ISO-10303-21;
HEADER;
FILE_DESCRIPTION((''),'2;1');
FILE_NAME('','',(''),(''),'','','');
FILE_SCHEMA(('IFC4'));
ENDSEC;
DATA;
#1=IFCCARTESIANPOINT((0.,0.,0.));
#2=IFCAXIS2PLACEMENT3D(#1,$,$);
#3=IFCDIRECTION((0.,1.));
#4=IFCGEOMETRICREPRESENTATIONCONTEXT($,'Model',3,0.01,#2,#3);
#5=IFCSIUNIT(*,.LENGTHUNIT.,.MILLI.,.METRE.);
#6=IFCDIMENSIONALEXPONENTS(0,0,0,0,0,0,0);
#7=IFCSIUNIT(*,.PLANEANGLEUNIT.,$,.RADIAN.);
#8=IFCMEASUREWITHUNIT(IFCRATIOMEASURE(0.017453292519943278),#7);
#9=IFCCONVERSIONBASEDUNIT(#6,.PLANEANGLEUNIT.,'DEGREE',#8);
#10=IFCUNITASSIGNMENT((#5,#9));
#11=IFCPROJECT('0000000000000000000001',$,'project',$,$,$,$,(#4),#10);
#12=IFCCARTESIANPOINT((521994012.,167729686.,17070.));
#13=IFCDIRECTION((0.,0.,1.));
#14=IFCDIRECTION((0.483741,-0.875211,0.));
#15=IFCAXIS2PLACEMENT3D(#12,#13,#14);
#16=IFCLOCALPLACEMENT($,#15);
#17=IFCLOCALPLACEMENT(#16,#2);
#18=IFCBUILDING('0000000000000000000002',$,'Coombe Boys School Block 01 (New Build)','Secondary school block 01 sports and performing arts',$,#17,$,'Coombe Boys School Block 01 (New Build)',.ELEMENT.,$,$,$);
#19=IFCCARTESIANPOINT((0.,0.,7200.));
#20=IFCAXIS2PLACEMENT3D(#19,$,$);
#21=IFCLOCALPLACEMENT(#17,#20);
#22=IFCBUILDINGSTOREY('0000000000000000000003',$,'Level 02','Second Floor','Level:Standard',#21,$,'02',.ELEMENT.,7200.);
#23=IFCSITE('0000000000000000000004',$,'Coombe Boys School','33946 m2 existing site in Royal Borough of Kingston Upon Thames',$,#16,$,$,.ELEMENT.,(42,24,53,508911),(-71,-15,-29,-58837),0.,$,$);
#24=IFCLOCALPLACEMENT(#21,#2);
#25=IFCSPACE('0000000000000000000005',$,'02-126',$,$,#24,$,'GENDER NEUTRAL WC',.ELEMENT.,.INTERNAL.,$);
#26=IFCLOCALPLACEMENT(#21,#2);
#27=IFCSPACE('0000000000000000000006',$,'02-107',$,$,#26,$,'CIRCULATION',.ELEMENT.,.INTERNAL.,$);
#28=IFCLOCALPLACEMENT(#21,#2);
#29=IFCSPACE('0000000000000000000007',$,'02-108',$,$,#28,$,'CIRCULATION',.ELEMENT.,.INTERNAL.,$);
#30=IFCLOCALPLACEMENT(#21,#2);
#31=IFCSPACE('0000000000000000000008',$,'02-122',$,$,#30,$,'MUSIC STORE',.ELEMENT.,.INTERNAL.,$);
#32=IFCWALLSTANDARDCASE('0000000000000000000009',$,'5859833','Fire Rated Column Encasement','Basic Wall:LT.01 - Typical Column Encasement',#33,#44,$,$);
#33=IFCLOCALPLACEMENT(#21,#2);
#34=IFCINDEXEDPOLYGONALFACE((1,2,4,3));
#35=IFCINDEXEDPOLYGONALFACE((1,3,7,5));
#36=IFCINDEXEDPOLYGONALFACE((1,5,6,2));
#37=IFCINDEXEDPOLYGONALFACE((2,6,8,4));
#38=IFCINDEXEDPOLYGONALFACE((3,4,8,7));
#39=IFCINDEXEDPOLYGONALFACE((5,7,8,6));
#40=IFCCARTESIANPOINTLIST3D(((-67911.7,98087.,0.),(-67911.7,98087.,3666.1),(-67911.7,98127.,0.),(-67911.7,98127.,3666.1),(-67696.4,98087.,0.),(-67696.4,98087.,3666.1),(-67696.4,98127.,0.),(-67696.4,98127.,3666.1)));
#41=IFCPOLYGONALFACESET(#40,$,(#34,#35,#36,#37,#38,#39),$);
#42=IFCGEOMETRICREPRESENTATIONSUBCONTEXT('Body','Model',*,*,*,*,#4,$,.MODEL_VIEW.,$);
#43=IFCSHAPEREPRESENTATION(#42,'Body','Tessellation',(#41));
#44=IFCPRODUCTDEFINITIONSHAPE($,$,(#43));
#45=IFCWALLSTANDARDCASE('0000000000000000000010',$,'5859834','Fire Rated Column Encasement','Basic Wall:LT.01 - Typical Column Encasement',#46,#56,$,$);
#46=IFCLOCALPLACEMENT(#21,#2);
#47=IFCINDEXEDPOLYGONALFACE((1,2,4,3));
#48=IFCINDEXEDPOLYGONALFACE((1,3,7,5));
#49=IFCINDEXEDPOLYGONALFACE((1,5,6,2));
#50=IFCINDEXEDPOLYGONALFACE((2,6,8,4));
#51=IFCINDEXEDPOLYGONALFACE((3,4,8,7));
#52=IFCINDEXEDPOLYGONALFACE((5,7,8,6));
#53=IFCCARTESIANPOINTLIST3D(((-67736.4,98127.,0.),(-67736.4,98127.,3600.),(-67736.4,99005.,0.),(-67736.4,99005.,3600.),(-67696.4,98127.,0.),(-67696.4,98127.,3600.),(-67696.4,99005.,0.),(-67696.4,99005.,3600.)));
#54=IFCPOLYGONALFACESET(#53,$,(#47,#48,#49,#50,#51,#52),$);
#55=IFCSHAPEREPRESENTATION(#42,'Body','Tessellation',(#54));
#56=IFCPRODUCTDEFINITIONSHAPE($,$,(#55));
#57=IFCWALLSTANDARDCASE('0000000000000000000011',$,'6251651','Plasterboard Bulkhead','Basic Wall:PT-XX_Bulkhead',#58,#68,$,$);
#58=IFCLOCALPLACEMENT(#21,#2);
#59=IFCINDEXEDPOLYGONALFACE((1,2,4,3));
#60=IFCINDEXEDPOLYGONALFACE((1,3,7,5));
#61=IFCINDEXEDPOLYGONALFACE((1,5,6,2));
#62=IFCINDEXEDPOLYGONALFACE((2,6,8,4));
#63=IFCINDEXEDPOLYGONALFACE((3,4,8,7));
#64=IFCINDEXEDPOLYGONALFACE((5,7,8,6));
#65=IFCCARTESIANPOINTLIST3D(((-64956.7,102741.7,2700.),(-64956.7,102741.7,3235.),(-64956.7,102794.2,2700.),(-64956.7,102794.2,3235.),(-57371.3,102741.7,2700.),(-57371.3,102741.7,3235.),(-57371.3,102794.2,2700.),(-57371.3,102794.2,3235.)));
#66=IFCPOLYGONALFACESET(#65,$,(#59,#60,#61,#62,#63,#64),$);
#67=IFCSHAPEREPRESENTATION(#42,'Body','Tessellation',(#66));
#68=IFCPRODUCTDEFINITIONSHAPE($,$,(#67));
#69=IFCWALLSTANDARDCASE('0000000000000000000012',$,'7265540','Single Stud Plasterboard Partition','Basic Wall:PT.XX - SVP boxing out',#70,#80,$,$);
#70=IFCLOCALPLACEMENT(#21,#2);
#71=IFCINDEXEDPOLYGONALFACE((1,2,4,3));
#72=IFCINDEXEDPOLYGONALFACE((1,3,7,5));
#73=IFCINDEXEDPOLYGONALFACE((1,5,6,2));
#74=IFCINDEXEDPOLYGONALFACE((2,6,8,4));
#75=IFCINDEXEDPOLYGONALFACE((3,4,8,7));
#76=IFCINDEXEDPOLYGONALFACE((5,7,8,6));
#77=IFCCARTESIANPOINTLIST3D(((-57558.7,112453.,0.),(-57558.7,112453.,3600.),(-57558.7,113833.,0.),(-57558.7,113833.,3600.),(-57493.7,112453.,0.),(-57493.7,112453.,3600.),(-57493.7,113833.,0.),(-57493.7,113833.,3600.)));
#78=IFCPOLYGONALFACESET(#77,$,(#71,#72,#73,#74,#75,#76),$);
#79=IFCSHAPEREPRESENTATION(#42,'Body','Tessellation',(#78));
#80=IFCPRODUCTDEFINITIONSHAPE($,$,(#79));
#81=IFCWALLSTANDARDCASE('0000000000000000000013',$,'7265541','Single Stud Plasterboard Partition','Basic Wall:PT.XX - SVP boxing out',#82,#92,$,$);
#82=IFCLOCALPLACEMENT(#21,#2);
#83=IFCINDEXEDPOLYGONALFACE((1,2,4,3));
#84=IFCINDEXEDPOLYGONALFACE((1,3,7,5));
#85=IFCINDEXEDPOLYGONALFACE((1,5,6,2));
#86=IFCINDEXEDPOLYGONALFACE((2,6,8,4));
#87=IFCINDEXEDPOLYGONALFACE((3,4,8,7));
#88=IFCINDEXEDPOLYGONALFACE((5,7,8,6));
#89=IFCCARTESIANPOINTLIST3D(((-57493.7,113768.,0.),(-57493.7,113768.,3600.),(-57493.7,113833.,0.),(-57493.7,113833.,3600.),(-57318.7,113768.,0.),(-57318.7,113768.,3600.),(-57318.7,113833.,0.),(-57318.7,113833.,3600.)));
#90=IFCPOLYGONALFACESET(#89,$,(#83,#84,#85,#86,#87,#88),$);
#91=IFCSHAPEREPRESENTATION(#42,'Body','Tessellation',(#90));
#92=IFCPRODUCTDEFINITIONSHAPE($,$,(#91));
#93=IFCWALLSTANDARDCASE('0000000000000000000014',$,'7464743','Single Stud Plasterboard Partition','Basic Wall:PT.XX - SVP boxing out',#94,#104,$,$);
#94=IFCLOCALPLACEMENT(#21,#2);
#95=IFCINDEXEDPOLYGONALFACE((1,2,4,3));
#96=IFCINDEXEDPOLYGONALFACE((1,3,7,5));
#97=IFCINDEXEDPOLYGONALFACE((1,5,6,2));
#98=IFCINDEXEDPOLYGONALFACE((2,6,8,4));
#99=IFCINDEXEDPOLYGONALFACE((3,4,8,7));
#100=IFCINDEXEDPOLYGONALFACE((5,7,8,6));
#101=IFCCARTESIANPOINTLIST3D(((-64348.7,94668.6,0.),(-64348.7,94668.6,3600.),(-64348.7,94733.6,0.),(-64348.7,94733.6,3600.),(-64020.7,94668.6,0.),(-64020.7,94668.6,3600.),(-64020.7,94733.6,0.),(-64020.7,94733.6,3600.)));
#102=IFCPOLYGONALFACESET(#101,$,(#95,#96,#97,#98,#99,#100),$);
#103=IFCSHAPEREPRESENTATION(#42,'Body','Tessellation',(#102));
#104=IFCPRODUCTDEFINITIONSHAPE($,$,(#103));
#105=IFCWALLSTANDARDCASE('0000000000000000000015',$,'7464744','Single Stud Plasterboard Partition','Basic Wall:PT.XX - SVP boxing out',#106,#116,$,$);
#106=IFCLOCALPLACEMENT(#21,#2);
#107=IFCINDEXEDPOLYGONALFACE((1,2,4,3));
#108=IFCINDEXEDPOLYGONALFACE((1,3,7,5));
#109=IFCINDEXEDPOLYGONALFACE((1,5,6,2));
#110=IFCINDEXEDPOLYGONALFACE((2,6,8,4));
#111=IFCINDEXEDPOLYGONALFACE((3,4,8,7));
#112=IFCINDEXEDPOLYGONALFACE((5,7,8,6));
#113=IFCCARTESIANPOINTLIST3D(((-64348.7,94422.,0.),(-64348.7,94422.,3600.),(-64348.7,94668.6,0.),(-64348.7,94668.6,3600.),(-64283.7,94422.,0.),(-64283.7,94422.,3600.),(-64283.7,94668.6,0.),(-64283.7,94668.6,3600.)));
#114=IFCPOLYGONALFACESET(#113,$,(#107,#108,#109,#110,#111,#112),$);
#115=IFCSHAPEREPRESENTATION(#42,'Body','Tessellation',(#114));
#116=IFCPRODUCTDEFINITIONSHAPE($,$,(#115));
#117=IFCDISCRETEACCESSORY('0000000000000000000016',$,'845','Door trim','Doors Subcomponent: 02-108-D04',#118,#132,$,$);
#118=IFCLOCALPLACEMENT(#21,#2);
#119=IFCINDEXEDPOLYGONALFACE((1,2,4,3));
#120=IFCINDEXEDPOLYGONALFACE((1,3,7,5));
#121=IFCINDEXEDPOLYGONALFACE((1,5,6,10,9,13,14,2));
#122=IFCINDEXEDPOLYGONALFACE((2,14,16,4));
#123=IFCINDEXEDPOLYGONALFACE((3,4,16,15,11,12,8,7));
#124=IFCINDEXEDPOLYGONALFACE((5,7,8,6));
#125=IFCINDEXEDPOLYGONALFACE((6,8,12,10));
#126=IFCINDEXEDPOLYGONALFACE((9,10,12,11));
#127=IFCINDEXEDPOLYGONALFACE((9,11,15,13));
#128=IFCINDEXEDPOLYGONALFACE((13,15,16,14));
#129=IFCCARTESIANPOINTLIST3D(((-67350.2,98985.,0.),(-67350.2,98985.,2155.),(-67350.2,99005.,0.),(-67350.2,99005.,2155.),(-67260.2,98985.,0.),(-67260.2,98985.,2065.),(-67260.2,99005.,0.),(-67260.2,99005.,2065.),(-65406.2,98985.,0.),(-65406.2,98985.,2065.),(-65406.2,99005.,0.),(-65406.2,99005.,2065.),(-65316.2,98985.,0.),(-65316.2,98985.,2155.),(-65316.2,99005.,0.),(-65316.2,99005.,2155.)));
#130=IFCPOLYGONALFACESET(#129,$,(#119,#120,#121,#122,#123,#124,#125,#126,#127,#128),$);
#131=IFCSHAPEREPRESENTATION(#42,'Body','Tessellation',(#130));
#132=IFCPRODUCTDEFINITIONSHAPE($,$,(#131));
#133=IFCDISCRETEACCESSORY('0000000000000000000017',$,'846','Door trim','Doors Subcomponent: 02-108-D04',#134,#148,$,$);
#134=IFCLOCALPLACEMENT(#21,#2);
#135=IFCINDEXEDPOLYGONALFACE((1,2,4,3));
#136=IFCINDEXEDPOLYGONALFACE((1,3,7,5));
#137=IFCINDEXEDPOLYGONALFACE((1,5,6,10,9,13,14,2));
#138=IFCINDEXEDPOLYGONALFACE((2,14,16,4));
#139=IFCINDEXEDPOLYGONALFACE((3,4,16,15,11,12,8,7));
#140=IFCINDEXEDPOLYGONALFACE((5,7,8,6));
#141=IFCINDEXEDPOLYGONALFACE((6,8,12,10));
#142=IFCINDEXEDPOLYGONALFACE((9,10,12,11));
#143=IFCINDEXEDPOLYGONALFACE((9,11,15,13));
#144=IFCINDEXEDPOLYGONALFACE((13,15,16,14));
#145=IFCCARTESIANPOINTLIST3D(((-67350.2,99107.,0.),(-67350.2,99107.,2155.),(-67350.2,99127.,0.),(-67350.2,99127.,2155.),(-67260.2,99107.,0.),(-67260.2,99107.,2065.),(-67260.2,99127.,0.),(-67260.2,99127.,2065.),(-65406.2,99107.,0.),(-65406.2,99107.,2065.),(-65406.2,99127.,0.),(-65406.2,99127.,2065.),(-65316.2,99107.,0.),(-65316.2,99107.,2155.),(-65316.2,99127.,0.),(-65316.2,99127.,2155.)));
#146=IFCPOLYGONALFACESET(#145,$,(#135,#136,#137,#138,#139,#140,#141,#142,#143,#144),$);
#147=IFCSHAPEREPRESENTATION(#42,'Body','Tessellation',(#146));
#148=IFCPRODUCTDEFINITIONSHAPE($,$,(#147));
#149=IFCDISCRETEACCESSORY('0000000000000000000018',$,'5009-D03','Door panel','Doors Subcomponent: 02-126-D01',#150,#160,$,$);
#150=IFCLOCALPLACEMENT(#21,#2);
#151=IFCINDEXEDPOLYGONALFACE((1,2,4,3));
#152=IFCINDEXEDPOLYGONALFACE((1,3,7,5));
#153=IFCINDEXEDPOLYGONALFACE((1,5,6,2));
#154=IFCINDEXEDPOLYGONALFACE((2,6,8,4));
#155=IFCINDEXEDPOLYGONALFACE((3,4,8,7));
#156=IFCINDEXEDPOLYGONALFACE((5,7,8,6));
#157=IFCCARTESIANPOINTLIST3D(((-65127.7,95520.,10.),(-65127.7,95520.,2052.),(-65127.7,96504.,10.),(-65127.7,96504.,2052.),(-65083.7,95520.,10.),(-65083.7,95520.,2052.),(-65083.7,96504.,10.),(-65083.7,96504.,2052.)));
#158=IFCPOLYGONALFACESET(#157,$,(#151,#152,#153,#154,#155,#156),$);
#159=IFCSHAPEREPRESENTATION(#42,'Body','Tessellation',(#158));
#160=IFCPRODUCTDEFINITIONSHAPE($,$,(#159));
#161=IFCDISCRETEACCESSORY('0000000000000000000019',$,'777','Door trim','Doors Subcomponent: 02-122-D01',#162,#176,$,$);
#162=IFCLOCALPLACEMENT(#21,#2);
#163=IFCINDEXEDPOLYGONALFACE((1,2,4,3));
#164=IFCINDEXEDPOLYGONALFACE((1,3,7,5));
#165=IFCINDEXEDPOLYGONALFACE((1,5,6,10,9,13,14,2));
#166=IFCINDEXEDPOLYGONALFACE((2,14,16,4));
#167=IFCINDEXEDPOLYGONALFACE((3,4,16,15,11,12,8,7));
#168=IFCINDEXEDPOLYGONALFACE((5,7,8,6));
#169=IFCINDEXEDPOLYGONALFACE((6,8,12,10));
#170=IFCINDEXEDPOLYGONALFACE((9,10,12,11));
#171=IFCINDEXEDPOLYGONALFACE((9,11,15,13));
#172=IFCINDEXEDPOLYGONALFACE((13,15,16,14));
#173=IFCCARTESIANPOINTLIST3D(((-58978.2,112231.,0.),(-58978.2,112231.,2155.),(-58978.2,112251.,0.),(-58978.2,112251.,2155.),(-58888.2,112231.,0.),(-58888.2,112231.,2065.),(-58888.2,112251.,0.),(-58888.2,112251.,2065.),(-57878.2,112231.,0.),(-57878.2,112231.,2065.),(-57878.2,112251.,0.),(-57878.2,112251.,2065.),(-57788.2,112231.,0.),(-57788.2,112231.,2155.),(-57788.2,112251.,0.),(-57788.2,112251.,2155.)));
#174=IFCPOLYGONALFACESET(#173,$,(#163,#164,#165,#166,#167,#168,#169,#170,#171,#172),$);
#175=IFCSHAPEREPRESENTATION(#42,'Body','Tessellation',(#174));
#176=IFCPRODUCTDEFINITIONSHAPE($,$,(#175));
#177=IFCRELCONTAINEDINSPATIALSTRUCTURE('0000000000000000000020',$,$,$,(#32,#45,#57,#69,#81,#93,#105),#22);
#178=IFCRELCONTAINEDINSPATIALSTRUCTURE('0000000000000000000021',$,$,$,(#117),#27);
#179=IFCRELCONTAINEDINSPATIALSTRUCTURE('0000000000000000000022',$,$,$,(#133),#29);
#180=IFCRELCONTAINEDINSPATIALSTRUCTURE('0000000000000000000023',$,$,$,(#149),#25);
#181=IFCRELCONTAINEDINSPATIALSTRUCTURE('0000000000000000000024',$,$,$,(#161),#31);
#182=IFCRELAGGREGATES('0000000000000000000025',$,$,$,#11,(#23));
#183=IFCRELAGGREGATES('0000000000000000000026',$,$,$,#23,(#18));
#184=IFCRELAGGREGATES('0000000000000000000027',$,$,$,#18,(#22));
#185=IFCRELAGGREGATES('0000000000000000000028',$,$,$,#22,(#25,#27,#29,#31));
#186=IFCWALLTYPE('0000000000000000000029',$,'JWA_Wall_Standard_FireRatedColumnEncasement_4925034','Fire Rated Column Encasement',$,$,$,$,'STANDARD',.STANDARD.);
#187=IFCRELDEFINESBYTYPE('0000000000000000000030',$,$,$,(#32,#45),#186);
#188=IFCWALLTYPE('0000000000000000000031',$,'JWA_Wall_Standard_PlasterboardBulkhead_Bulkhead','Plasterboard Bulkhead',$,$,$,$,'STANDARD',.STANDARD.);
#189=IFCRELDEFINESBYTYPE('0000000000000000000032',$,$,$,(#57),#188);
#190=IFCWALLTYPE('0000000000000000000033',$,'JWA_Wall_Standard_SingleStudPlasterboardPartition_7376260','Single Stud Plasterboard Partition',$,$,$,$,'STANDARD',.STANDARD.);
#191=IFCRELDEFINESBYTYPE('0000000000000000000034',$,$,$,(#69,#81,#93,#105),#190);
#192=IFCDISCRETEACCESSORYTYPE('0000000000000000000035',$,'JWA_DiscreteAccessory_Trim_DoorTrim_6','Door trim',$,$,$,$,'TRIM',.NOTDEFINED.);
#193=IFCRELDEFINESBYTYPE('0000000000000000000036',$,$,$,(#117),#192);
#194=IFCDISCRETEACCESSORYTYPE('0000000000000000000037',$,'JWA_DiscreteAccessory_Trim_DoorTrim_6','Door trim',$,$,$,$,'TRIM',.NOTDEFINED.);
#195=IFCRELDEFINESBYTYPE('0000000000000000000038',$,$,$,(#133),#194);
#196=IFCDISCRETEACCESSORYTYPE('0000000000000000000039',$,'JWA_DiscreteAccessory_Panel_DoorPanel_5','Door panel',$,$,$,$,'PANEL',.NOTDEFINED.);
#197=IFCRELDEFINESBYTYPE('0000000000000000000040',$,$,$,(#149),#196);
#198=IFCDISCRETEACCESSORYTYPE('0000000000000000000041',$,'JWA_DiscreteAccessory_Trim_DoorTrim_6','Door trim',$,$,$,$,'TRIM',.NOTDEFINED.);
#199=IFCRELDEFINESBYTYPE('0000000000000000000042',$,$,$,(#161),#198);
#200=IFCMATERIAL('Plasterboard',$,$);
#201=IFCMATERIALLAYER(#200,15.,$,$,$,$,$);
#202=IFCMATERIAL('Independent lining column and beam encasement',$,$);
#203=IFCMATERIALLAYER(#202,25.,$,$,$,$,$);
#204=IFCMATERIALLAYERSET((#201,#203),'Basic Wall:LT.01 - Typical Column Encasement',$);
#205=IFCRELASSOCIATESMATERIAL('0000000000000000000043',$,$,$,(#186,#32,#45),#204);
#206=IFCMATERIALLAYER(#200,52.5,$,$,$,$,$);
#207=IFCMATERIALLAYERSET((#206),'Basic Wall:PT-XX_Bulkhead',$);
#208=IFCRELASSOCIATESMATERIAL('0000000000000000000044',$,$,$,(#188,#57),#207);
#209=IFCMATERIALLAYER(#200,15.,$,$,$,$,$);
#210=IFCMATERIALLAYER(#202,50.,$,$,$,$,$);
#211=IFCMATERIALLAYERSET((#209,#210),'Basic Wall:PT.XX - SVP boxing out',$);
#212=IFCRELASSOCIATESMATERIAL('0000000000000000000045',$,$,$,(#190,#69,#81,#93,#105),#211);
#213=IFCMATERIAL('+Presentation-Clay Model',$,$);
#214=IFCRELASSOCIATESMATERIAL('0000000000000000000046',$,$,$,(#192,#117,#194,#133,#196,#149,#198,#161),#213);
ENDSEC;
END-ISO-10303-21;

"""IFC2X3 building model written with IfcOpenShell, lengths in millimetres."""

from ifc_helpers import new_model, entity, si_unit, converted_unit, direction, frame, frame_2d, origin, origin_2d_with_axis, place, context, subcontext, project, spatial, polyline, rectangle, outline, extrude, source, transform, mapped, material, layer, layer_set, layer_usage, type_object, type_shapes, element, save


model = new_model("IFC2X3")

# Units and contexts
model_context = context("Model", 3, precision=0.01, world=origin(), true_north=direction((0.0, 1.0)))
body_context = subcontext(model_context, "Body", "Model", "MODEL_VIEW")
ifc_project = project(units=[si_unit("LENGTHUNIT", "METRE", prefix="MILLI"), converted_unit("PLANEANGLEUNIT", "DEGREE", entity("IfcRatioMeasure", 0.017453292519943278), si_unit("PLANEANGLEUNIT", "RADIAN"), dimensions=[0, 0, 0, 0, 0, 0, 0])], contexts=[model_context])

# Site, building, storey
site_placement = place(None, frame((521994012.0, 167729686.0, 17070.0), z_axis=(0.0, 0.0, 1.0), x_axis=(0.483741, -0.875211, 0.0)))
site = spatial("IfcSite", under=ifc_project, at=site_placement, Name="Coombe Boys School", Description="33946 m2 existing site in Royal Borough of Kingston Upon Thames", CompositionType="ELEMENT", RefLatitude=(42, 24, 53, 508911), RefLongitude=(-71, -15, -29, -58837), RefElevation=0.0)
building_placement = place(site_placement, origin())
building = spatial("IfcBuilding", under=site, at=building_placement, Name="Coombe Boys School Block 01 (New Build)", Description="Secondary school block 01 sports and performing arts", LongName="Coombe Boys School Block 01 (New Build)", CompositionType="ELEMENT")
storey_placement = place(building_placement, frame((0.0, 0.0, 7200.0)))
storey = spatial("IfcBuildingStorey", under=building, at=storey_placement, Name="Level 02", Description="Second Floor", ObjectType="Level:Standard", LongName="02", CompositionType="ELEMENT", Elevation=7200.0)

# Shared definitions
ifc_material_1 = material(Name="Plasterboard")

# Walls
ifc_layer_1 = layer(ifc_material_1, 15.0)
ifc_material_2 = material(Name="Independent lining column and beam encasement")
ifc_layer_2 = layer(ifc_material_2, 25.0)
ifc_layer_set_1 = layer_set([ifc_layer_1, ifc_layer_2], Name="Basic Wall:LT.01 - Typical Column Encasement")
ifc_layer_usage_1 = layer_usage(ifc_layer_set_1, "AXIS2", "POSITIVE", -20.0)
wall_type_1 = type_object("IfcWallType", Name="JWA_Wall_Standard_FireRatedColumnEncasement_4925034", Description="Fire Rated Column Encasement", ElementType="STANDARD", PredefinedType="STANDARD", material=ifc_layer_set_1)
wall_1_placement = place(storey_placement, frame((-67911.7, 98107.0, 0.0)))
element("IfcWallStandardCase", 1, at=wall_1_placement, inside=storey, type_object=wall_type_1, material=ifc_layer_usage_1, Name="5859833", Description="Fire Rated Column Encasement", ObjectType="Basic Wall:LT.01 - Typical Column Encasement", context=body_context, shape_type="SweptSolid", body=[
    extrude(rectangle(XDim=215.3, YDim=40.0, at=frame_2d((107.7, 0.0), x_axis=(-1.0, 0.0))), origin(), (0.0, 0.0, 1.0), 3666.1),
])
wall_2_placement = place(storey_placement, frame((-67716.4, 98127.0, 0.0), z_axis=(0.0, 0.0, 1.0), x_axis=(0.0, 1.0, 0.0)))
element("IfcWallStandardCase", 2, at=wall_2_placement, inside=storey, type_object=wall_type_1, material=ifc_layer_usage_1, Name="5859834", Description="Fire Rated Column Encasement", ObjectType="Basic Wall:LT.01 - Typical Column Encasement", context=body_context, shape_type="SweptSolid", body=[
    extrude(rectangle(XDim=878.0, YDim=40.0, at=frame_2d((439.0, 0.0), x_axis=(-1.0, 0.0))), origin(), (0.0, 0.0, 1.0), 3600.0),
])
ifc_layer_3 = layer(ifc_material_1, 52.5)
ifc_layer_set_2 = layer_set([ifc_layer_3], Name="Basic Wall:PT-XX_Bulkhead")
ifc_layer_usage_2 = layer_usage(ifc_layer_set_2, "AXIS2", "NEGATIVE", 26.2)
wall_type_2 = type_object("IfcWallType", Name="JWA_Wall_Standard_PlasterboardBulkhead_Bulkhead", Description="Plasterboard Bulkhead", ElementType="STANDARD", PredefinedType="STANDARD", material=ifc_layer_set_2)
wall_3_placement = place(storey_placement, frame((-64956.7, 102768.0, 2700.0)))
element("IfcWallStandardCase", 3, at=wall_3_placement, inside=storey, type_object=wall_type_2, material=ifc_layer_usage_2, Name="6251651", Description="Plasterboard Bulkhead", ObjectType="Basic Wall:PT-XX_Bulkhead", context=body_context, shape_type="SweptSolid", body=[
    extrude(rectangle(XDim=7585.4, YDim=52.5, at=frame_2d((3792.7, 0.0), x_axis=(-1.0, 0.0))), origin(), (0.0, 0.0, 1.0), 535.0),
])
ifc_layer_4 = layer(ifc_material_1, 15.0)
ifc_layer_5 = layer(ifc_material_2, 50.0)
ifc_layer_set_3 = layer_set([ifc_layer_4, ifc_layer_5], Name="Basic Wall:PT.XX - SVP boxing out")
ifc_layer_usage_3 = layer_usage(ifc_layer_set_3, "AXIS2", "NEGATIVE", 32.5)
wall_type_3 = type_object("IfcWallType", Name="JWA_Wall_Standard_SingleStudPlasterboardPartition_7376260", Description="Single Stud Plasterboard Partition", ElementType="STANDARD", PredefinedType="STANDARD", material=ifc_layer_set_3)
wall_4_placement = place(storey_placement, frame((-57526.2, 112453.0, 0.0), z_axis=(0.0, 0.0, 1.0), x_axis=(0.0, 1.0, 0.0)))
element("IfcWallStandardCase", 4, at=wall_4_placement, inside=storey, type_object=wall_type_3, material=ifc_layer_usage_3, Name="7265540", Description="Single Stud Plasterboard Partition", ObjectType="Basic Wall:PT.XX - SVP boxing out", context=body_context, shape_type="SweptSolid", body=[
    extrude(rectangle(XDim=1380.0, YDim=65.0, at=frame_2d((690.0, 0.0), x_axis=(-1.0, 0.0))), origin(), (0.0, 0.0, 1.0), 3600.0),
])
wall_5_placement = place(storey_placement, frame((-57493.7, 113800.5, 0.0)))
element("IfcWallStandardCase", 5, at=wall_5_placement, inside=storey, type_object=wall_type_3, material=ifc_layer_usage_3, Name="7265541", Description="Single Stud Plasterboard Partition", ObjectType="Basic Wall:PT.XX - SVP boxing out", context=body_context, shape_type="SweptSolid", body=[
    extrude(rectangle(XDim=175.0, YDim=65.0, at=frame_2d((87.5, 0.0), x_axis=(-1.0, 0.0))), origin(), (0.0, 0.0, 1.0), 3600.0),
])
ifc_layer_usage_4 = layer_usage(ifc_layer_set_3, "AXIS2", "POSITIVE", -32.5)
wall_6_placement = place(storey_placement, frame((-64020.7, 94701.1, 0.0), z_axis=(0.0, 0.0, 1.0), x_axis=(-1.0, 0.0, 0.0)))
element("IfcWallStandardCase", 6, at=wall_6_placement, inside=storey, type_object=wall_type_3, material=ifc_layer_usage_4, Name="7464743", Description="Single Stud Plasterboard Partition", ObjectType="Basic Wall:PT.XX - SVP boxing out", context=body_context, shape_type="SweptSolid", body=[
    extrude(rectangle(XDim=328.0, YDim=65.0, at=frame_2d((164.0, 0.0), x_axis=(-1.0, 0.0))), origin(), (0.0, 0.0, 1.0), 3600.0),
])
wall_7_placement = place(storey_placement, frame((-64316.2, 94668.6, 0.0), z_axis=(0.0, 0.0, 1.0), x_axis=(0.0, -1.0, 0.0)))
element("IfcWallStandardCase", 7, at=wall_7_placement, inside=storey, type_object=wall_type_3, material=ifc_layer_usage_4, Name="7464744", Description="Single Stud Plasterboard Partition", ObjectType="Basic Wall:PT.XX - SVP boxing out", context=body_context, shape_type="SweptSolid", body=[
    extrude(rectangle(XDim=246.6, YDim=65.0, at=frame_2d((123.3, 0.0), x_axis=(-1.0, 0.0))), origin(), (0.0, 0.0, 1.0), 3600.0),
])

# Shared definitions
space_1_placement = place(storey_placement, origin())
space_1 = spatial("IfcSpace", under=storey, at=space_1_placement, Name="02-126", LongName="GENDER NEUTRAL WC", CompositionType="ELEMENT", InteriorOrExteriorSpace="INTERNAL")

# Shared definitions
ifc_material_3 = material(Name="+Presentation-Clay Model")

# Shared definitions
space_2_placement = place(storey_placement, origin())
space_2 = spatial("IfcSpace", under=storey, at=space_2_placement, Name="02-107", LongName="CIRCULATION", CompositionType="ELEMENT", InteriorOrExteriorSpace="INTERNAL")

# Discrete accessory
discrete_accessory_type_1 = type_object("IfcDiscreteAccessoryType", Name="JWA_DiscreteAccessory_Trim_DoorTrim_6", Description="Door trim", ElementType="TRIM", material=ifc_material_3)
shared_shape_1 = source(origin(), body_context, "Body", "SweptSolid", [
    extrude(outline(polyline([(-1055.0, -1017.0), (1100.0, -1017.0), (1100.0, 1017.0), (-1055.0, 1017.0), (-1055.0, 927.0), (1010.0, 927.0), (1010.0, -927.0), (-1055.0, -927.0), (-1055.0, -1017.0)])), frame((0.0, -20.0, 1055.0), z_axis=(0.0, 1.0, 0.0), x_axis=(0.0, 0.0, 1.0)), (0.0, 0.0, 1.0), 20.0),
])
type_shapes(discrete_accessory_type_1, [shared_shape_1])
discrete_accessory_1_placement = place(space_2_placement, frame((-66333.2, 99005.0, 0.0)))
element("IfcDiscreteAccessory", 8, at=discrete_accessory_1_placement, inside=space_2, type_object=discrete_accessory_type_1, material=ifc_material_3, Name="845", Description="Door trim", ObjectType="Doors Subcomponent: 02-108-D04", context=body_context, shape_type="MappedRepresentation", body=[
    mapped(shared_shape_1, transform((0.0, 0.0, 0.0), scale=1.0)),
])

# Shared definitions
space_3_placement = place(storey_placement, origin())
space_3 = spatial("IfcSpace", under=storey, at=space_3_placement, Name="02-108", LongName="CIRCULATION", CompositionType="ELEMENT", InteriorOrExteriorSpace="INTERNAL")

# Discrete accessories
discrete_accessory_type_2 = type_object("IfcDiscreteAccessoryType", Name="JWA_DiscreteAccessory_Trim_DoorTrim_6", Description="Door trim", ElementType="TRIM", material=ifc_material_3)
shared_shape_2 = source(origin(), body_context, "Body", "SweptSolid", [
    extrude(outline(polyline([(927.0, -1055.0), (1017.0, -1055.0), (1017.0, 1100.0), (-1017.0, 1100.0), (-1017.0, -1055.0), (-927.0, -1055.0), (-927.0, 1010.0), (927.0, 1010.0), (927.0, -1055.0)])), frame((0.0, 0.0, 1055.0), z_axis=(0.0, 1.0, 0.0), x_axis=(-1.0, 0.0, 0.0)), (0.0, 0.0, 1.0), 20.0),
])
type_shapes(discrete_accessory_type_2, [shared_shape_2])
discrete_accessory_2_placement = place(space_3_placement, frame((-66333.2, 99107.0, 0.0)))
element("IfcDiscreteAccessory", 9, at=discrete_accessory_2_placement, inside=space_3, type_object=discrete_accessory_type_2, material=ifc_material_3, Name="846", Description="Door trim", ObjectType="Doors Subcomponent: 02-108-D04", context=body_context, shape_type="MappedRepresentation", body=[
    mapped(shared_shape_2, transform((0.0, 0.0, 0.0), scale=1.0)),
])
discrete_accessory_type_3 = type_object("IfcDiscreteAccessoryType", Name="JWA_DiscreteAccessory_Panel_DoorPanel_5", Description="Door panel", ElementType="PANEL", material=ifc_material_3)
shared_shape_3 = source(origin(), body_context, "Body", "SweptSolid", [
    extrude(rectangle(XDim=44.0, YDim=984.0, at=origin_2d_with_axis()), frame((0.0, 22.0, 10.0), z_axis=(0.0, 0.0, 1.0), x_axis=(0.0, -1.0, 0.0)), (0.0, 0.0, 1.0), 2042.0),
])
type_shapes(discrete_accessory_type_3, [shared_shape_3])
discrete_accessory_3_placement = place(space_1_placement, frame((-65083.7, 96012.0, 0.0), z_axis=(0.0, 0.0, 1.0), x_axis=(0.0, 1.0, 0.0)))
element("IfcDiscreteAccessory", 10, at=discrete_accessory_3_placement, inside=space_1, type_object=discrete_accessory_type_3, material=ifc_material_3, Name="5009-D03", Description="Door panel", ObjectType="Doors Subcomponent: 02-126-D01", context=body_context, shape_type="MappedRepresentation", body=[
    mapped(shared_shape_3, transform((0.0, 0.0, 0.0), scale=1.0)),
])

# Shared definitions
space_4_placement = place(storey_placement, origin())
space_4 = spatial("IfcSpace", under=storey, at=space_4_placement, Name="02-122", LongName="MUSIC STORE", CompositionType="ELEMENT", InteriorOrExteriorSpace="INTERNAL")

# Discrete accessory
discrete_accessory_type_4 = type_object("IfcDiscreteAccessoryType", Name="JWA_DiscreteAccessory_Trim_DoorTrim_6", Description="Door trim", ElementType="TRIM", material=ifc_material_3)
shared_shape_4 = source(origin(), body_context, "Body", "SweptSolid", [
    extrude(outline(polyline([(-1055.0, -595.0), (1100.0, -595.0), (1100.0, 595.0), (-1055.0, 595.0), (-1055.0, 505.0), (1010.0, 505.0), (1010.0, -505.0), (-1055.0, -505.0), (-1055.0, -595.0)])), frame((0.0, -20.0, 1055.0), z_axis=(0.0, 1.0, 0.0), x_axis=(0.0, 0.0, 1.0)), (0.0, 0.0, 1.0), 20.0),
])
type_shapes(discrete_accessory_type_4, [shared_shape_4])
discrete_accessory_4_placement = place(space_4_placement, frame((-58383.2, 112251.0, 0.0)))
element("IfcDiscreteAccessory", 11, at=discrete_accessory_4_placement, inside=space_4, type_object=discrete_accessory_type_4, material=ifc_material_3, Name="777", Description="Door trim", ObjectType="Doors Subcomponent: 02-122-D01", context=body_context, shape_type="MappedRepresentation", body=[
    mapped(shared_shape_4, transform((0.0, 0.0, 0.0), scale=1.0)),
])

save(model, "model.ifc")
